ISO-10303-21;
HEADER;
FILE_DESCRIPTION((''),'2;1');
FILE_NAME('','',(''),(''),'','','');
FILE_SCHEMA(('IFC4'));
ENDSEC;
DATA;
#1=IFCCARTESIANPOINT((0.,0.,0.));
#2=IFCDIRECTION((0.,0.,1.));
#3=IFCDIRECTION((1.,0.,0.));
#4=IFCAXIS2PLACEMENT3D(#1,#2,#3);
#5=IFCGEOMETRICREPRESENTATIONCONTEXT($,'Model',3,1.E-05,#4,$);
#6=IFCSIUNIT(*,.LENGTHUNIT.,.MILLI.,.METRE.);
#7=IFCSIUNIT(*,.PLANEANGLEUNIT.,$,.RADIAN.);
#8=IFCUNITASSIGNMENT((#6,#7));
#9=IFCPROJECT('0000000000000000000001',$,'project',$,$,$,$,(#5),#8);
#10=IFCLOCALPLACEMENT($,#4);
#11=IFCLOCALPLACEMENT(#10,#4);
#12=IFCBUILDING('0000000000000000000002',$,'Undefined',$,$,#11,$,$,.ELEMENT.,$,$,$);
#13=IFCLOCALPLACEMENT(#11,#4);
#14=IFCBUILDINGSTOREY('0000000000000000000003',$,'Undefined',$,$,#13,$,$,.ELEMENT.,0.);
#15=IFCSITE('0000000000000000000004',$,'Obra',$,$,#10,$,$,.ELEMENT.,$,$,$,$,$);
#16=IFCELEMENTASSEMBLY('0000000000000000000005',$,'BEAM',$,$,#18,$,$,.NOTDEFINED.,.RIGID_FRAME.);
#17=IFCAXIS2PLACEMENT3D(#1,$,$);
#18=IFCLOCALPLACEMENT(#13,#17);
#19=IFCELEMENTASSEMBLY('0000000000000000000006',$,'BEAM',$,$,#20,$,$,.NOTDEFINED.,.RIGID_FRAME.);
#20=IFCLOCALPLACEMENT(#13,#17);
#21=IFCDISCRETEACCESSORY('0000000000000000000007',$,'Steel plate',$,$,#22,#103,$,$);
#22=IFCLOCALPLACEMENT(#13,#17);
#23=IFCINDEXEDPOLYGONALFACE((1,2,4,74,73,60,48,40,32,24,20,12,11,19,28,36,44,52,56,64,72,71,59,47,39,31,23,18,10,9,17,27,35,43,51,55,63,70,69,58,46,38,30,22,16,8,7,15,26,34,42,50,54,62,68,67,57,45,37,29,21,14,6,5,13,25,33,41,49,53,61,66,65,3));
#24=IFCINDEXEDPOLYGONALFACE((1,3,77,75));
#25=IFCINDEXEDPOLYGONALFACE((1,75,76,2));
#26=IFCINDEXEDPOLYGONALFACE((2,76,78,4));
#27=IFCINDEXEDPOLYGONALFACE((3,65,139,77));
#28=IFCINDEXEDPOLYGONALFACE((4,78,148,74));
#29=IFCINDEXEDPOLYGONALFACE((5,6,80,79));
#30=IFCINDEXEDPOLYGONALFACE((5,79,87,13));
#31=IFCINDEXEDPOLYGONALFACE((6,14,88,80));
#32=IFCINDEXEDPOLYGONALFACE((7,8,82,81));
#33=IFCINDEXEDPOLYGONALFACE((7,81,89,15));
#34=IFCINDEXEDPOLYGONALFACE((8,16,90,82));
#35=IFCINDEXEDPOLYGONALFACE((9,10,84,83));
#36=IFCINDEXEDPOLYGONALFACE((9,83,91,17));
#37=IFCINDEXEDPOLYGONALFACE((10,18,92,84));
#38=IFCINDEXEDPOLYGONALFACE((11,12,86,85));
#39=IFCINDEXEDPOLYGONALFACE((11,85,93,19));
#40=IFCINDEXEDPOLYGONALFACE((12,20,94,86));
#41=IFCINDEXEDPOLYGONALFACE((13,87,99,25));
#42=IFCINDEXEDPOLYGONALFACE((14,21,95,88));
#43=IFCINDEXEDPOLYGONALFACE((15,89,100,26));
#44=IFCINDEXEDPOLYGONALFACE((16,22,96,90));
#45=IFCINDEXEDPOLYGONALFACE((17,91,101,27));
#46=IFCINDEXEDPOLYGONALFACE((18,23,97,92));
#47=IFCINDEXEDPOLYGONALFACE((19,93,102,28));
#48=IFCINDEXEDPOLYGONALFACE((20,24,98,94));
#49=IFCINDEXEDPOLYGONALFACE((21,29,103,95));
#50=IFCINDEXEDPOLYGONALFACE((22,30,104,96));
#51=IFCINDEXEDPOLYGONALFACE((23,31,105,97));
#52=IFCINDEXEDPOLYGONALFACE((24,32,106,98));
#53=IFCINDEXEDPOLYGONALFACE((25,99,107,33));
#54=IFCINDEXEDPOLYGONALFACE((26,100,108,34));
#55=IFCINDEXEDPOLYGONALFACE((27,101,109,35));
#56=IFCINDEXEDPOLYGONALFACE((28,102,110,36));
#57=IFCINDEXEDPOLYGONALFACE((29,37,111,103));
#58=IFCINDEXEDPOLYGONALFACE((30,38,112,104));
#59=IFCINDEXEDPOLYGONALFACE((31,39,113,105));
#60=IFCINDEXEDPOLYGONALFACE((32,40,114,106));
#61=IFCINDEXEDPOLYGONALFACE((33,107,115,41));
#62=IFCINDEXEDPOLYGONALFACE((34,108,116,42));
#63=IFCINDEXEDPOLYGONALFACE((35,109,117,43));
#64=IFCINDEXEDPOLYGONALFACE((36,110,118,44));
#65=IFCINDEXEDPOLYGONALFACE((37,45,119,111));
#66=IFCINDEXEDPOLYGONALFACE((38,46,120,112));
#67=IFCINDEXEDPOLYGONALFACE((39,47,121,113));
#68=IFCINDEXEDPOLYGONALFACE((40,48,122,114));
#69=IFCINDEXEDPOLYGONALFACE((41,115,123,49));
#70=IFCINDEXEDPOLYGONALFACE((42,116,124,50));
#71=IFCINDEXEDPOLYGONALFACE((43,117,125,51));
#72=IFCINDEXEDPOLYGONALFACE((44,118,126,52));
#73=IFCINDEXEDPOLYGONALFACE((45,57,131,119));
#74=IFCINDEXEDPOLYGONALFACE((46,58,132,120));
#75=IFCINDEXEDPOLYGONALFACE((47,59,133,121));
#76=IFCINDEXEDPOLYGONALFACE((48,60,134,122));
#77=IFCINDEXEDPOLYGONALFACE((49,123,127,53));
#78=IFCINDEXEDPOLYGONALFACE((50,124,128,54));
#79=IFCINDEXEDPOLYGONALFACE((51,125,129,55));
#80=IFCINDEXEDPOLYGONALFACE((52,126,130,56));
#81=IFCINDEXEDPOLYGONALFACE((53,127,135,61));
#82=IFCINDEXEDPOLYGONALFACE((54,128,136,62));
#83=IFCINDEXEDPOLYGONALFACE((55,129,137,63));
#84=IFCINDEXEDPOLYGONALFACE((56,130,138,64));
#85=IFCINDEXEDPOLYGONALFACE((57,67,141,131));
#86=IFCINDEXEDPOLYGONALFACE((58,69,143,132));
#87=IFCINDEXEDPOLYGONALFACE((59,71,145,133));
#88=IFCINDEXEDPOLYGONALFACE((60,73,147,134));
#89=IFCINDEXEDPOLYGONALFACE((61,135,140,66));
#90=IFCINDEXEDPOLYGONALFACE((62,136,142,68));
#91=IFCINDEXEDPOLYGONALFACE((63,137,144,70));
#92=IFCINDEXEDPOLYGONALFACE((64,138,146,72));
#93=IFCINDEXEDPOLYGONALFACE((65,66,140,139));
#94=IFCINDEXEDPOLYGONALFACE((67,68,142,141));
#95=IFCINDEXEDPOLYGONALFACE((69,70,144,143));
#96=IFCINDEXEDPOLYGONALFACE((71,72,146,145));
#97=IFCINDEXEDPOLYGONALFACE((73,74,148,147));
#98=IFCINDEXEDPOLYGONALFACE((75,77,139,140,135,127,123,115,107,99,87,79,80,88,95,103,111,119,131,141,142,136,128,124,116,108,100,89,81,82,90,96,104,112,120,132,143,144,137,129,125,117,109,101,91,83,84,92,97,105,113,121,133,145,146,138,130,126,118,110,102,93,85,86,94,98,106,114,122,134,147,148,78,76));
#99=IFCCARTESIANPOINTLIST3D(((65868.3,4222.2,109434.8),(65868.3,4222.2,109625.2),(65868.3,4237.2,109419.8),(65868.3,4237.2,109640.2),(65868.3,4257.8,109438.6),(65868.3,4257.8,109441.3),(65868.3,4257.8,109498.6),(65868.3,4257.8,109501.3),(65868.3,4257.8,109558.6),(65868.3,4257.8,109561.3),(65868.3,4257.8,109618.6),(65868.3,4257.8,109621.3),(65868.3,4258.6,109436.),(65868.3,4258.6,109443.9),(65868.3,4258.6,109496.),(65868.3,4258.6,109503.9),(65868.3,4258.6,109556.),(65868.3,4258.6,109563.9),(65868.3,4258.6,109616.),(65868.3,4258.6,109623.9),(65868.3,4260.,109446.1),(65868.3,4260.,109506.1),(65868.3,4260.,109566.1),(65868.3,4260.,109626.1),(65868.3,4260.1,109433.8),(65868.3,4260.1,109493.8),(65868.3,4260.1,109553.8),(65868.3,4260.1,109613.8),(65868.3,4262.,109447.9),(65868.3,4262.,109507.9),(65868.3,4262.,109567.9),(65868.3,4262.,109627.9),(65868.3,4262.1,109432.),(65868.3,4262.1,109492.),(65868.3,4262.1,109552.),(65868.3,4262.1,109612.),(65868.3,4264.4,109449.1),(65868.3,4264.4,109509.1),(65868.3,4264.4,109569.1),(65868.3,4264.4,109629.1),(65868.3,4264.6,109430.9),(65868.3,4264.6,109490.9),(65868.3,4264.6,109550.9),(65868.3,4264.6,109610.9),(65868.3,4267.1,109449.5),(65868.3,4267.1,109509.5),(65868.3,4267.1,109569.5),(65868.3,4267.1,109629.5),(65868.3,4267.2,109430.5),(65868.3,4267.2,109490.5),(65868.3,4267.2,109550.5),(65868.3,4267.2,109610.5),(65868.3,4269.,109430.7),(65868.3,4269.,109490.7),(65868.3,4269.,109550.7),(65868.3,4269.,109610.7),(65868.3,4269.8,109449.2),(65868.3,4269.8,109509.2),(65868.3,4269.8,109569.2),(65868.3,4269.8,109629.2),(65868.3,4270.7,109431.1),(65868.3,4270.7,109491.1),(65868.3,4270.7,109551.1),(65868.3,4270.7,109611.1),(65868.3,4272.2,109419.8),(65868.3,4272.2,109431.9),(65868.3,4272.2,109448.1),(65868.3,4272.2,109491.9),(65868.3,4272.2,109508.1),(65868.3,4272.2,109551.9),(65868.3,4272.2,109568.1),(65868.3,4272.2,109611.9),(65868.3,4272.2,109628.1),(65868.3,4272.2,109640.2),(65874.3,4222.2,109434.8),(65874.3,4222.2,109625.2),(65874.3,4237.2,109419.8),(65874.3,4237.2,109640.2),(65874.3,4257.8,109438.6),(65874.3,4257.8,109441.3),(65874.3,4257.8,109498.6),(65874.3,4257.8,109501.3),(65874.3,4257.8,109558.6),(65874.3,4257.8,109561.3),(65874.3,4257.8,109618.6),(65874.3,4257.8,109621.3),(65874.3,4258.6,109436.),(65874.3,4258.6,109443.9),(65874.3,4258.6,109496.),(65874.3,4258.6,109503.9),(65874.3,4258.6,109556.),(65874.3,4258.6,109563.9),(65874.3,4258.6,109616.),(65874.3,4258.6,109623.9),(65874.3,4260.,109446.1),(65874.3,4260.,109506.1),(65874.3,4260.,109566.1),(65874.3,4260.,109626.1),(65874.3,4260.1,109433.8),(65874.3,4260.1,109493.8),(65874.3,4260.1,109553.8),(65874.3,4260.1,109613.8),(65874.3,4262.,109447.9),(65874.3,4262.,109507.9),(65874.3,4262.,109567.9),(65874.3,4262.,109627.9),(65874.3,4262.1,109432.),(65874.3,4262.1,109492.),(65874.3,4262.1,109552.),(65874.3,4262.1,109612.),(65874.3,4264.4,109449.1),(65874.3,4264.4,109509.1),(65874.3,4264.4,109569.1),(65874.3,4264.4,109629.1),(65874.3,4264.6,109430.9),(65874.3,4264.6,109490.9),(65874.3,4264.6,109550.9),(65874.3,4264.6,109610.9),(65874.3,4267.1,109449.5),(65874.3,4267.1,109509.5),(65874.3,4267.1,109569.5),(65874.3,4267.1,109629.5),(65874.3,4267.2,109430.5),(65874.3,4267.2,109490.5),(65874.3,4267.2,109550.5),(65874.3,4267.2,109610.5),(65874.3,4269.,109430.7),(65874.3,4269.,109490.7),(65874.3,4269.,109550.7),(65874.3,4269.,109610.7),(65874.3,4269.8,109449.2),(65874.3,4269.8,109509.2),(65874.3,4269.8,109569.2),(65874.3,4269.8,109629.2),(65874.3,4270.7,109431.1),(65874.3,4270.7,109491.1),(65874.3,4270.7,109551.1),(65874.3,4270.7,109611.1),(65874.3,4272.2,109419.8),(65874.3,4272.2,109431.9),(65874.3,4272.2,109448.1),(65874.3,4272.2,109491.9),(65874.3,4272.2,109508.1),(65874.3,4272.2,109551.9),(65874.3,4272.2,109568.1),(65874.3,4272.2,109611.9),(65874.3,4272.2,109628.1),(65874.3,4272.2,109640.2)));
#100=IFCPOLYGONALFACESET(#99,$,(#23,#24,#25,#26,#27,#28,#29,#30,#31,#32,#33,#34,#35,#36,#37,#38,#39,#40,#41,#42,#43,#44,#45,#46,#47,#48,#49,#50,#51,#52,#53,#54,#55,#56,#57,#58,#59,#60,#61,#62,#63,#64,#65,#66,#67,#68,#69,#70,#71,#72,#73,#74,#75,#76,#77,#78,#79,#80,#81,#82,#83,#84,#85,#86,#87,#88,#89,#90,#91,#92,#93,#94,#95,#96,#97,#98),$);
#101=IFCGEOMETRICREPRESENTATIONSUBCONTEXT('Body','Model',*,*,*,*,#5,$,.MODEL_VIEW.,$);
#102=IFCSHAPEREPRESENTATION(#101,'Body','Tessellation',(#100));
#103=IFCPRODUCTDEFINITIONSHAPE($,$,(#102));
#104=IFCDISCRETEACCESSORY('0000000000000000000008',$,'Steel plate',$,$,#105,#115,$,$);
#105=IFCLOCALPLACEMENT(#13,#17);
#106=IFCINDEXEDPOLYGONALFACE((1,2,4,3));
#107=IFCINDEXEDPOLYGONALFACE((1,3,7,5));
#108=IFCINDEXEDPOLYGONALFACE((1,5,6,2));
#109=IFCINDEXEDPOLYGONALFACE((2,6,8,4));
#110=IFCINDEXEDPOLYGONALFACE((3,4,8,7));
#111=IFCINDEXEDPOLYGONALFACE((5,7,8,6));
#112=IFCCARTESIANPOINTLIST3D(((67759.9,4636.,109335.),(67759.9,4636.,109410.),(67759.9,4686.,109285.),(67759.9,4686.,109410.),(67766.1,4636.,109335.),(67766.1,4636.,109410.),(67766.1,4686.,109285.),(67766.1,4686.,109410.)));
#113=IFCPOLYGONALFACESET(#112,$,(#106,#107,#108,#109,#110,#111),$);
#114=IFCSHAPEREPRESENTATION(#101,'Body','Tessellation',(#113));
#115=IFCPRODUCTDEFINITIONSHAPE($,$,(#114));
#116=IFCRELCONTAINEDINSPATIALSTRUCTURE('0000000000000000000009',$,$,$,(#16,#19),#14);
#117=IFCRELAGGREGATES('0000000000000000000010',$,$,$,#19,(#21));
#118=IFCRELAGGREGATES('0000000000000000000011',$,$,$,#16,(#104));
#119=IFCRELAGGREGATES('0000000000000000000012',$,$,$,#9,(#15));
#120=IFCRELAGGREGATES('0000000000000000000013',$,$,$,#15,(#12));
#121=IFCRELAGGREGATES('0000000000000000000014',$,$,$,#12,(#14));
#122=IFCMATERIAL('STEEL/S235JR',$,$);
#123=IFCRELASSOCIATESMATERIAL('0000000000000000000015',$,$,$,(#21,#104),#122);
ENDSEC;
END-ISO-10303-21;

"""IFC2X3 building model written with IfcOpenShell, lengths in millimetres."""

from ifc_helpers import new_model, si_unit, frame, origin_with_axes, origin_2d_with_axis, place, context, subcontext, project, spatial, polyline, circle, outline, extrude, source, transform, mapped, material, element, aggregate, save


model = new_model("IFC2X3")

# Units and contexts
model_context = context("Model", 3, precision=1e-05, world=origin_with_axes())
body_context = subcontext(model_context, "Body", "Model", "MODEL_VIEW")
ifc_project = project(units=[si_unit("LENGTHUNIT", "METRE", prefix="MILLI"), si_unit("PLANEANGLEUNIT", "RADIAN")], contexts=[model_context])

# Site, building, storey
site_placement = place(None, origin_with_axes())
site = spatial("IfcSite", under=ifc_project, at=site_placement, Name="Obra", CompositionType="ELEMENT")
building_placement = place(site_placement, origin_with_axes())
building = spatial("IfcBuilding", under=site, at=building_placement, Name="Undefined", CompositionType="ELEMENT")
storey_placement = place(building_placement, origin_with_axes())
storey = spatial("IfcBuildingStorey", under=building, at=storey_placement, Name="Undefined", CompositionType="ELEMENT", Elevation=0.0)

# Shared definitions
ifc_material_1 = material(Name="STEEL/S235JR")

# Shared definitions
shared_shape_1 = source(origin_with_axes(), body_context, "Body", "SweptSolid", [
    extrude(circle(Radius=9.5, at=origin_2d_with_axis()), frame((0.0, -9.2, 0.0), z_axis=(0.0, 1.0, 0.0), x_axis=(1.0, 0.0, 0.0)), (0.0, 0.0, 1.0), 6.2),
])

# Element assembly
assembly_1_placement = place(storey_placement, origin_with_axes())
assembly_1 = element("IfcElementAssembly", 1, at=assembly_1_placement, inside=storey, Name="BEAM", AssemblyPlace="NOTDEFINED", PredefinedType="RIGID_FRAME")

# Element assembly
assembly_2_placement = place(storey_placement, origin_with_axes())
assembly_2 = element("IfcElementAssembly", 2, at=assembly_2_placement, inside=storey, Name="BEAM", AssemblyPlace="NOTDEFINED", PredefinedType="RIGID_FRAME")

# Discrete accessory, opening
discrete_accessory_1_placement = place(assembly_2_placement, frame((65871.3, 4272.2, 109419.8), z_axis=(-1.0, 0.0, 0.0), x_axis=(0.0, -1.0, 0.0)))
discrete_accessory_1 = element("IfcDiscreteAccessory", 3, at=discrete_accessory_1_placement, material=ifc_material_1, Name="Steel plate", context=body_context, shape_type="SweptSolid", body=[
    extrude(outline(polyline([(0.0, 0.0), (35.0, 0.0), (50.0, 15.0), (50.0, 205.4), (35.0, 220.4), (0.0, 220.4), (0.0, 0.0)])), frame((0.0, 0.0, -3.0), z_axis=(0.0, 0.0, 1.0), x_axis=(1.0, 0.0, 0.0)), (0.0, 0.0, 1.0), 6.0),
])
opening_1_placement = place(assembly_2_placement, frame((65865.2, 4232.2, 109650.0), z_axis=(0.0, 1.0, 0.0), x_axis=(0.0, 0.0, -1.0)))
element("IfcOpeningElement", 4, at=opening_1_placement, cuts=discrete_accessory_1, ObjectType="Opening", context=body_context, shape_type="MappedRepresentation", body=[
    mapped(shared_shape_1, transform((30.0, 0.0, 35.0))),
    mapped(shared_shape_1, transform((90.0, 0.0, 35.0))),
    mapped(shared_shape_1, transform((150.0, 0.0, 35.0))),
    mapped(shared_shape_1, transform((210.0, 0.0, 35.0))),
])
aggregate(assembly_2, [discrete_accessory_1])

# Discrete accessory
discrete_accessory_2_placement = place(assembly_1_placement, frame((67763.0, 4686.0, 109410.0), z_axis=(-1.0, 0.0, 0.0), x_axis=(0.0, 0.0, -1.0)))
discrete_accessory_2 = element("IfcDiscreteAccessory", 5, at=discrete_accessory_2_placement, material=ifc_material_1, Name="Steel plate", context=body_context, shape_type="SweptSolid", body=[
    extrude(outline(polyline([(0.0, 0.0), (150.0, 0.0), (150.0, -25.0), (75.0, 50.0), (0.0, 50.0), (0.0, 0.0)])), frame((0.0, 0.0, -3.1), z_axis=(0.0, 0.0, 1.0), x_axis=(1.0, 0.0, 0.0)), (0.0, 0.0, 1.0), 6.2),
])
aggregate(assembly_1, [discrete_accessory_2])

save(model, "model.ifc")
